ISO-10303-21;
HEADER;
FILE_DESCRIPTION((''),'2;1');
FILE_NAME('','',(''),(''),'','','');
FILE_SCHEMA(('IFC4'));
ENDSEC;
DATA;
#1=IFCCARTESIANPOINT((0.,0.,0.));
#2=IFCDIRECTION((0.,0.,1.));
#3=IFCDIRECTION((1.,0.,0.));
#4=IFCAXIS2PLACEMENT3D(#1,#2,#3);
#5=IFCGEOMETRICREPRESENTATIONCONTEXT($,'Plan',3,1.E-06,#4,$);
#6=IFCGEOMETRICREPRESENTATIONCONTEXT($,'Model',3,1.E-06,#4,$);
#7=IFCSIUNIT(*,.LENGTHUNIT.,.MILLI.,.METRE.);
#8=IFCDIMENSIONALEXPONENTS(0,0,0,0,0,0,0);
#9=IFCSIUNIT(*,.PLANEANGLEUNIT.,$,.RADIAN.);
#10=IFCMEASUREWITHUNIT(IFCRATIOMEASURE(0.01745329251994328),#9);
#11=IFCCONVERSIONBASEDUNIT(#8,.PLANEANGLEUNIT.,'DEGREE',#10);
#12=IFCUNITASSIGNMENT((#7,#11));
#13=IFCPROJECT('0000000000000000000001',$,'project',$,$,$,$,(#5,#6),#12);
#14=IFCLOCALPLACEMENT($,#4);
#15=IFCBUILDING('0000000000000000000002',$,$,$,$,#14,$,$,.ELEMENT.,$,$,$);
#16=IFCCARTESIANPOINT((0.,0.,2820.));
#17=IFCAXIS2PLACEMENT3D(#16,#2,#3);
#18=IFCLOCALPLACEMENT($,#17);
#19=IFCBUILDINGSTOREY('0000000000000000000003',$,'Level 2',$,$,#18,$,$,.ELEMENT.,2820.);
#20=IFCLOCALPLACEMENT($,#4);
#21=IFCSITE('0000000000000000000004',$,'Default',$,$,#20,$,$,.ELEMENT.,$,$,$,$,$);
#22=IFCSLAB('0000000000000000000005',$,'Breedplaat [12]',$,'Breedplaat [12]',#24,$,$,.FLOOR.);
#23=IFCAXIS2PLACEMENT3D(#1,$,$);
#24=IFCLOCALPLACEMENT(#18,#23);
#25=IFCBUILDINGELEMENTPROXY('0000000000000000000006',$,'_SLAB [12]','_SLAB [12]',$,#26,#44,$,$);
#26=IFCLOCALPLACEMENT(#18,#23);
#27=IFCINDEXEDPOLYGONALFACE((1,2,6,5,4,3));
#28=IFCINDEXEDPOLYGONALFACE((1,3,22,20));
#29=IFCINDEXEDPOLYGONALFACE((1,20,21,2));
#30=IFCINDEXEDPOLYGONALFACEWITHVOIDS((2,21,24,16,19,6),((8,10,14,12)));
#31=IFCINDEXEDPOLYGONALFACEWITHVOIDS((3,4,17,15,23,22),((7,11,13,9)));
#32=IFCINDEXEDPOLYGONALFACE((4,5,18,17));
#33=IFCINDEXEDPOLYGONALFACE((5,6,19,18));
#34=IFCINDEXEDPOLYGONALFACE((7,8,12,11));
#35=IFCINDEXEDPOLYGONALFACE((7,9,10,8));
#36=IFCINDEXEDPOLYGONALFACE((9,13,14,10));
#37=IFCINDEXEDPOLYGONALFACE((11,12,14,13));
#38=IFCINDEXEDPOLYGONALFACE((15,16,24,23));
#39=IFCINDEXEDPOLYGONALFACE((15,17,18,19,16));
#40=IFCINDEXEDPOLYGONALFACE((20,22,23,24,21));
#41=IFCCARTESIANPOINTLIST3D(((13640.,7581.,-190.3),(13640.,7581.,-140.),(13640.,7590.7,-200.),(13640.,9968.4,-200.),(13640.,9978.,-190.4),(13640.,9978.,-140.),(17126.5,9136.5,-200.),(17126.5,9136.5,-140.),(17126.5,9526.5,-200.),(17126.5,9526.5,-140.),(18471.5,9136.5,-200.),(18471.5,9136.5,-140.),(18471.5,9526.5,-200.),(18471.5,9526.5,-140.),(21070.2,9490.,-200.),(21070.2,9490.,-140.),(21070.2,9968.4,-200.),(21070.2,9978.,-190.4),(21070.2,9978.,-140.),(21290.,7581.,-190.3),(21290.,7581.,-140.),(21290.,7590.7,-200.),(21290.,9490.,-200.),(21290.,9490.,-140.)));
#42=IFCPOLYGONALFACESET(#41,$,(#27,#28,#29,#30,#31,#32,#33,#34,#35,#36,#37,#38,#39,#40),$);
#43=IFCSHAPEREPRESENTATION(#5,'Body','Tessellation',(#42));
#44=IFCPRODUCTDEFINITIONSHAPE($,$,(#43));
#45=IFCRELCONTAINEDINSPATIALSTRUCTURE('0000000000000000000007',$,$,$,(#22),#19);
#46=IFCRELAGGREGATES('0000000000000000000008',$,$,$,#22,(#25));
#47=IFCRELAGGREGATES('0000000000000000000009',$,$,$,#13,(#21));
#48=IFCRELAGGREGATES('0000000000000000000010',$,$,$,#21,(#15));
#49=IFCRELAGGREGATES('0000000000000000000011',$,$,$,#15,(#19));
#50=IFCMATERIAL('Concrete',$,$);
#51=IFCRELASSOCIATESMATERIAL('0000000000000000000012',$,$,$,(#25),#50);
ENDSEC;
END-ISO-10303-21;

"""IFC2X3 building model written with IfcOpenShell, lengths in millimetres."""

from ifc_helpers import new_model, entity, si_unit, converted_unit, frame, origin_with_axes, origin_2d_with_axis, place, context, project, spatial, polyline, rectangle, outline, extrude, material, element, aggregate, save


model = new_model("IFC2X3")

# Units and contexts
plan_context = context("Plan", 3, precision=1e-06, world=origin_with_axes())
model_context = context("Model", 3, precision=1e-06, world=origin_with_axes())
ifc_project = project(units=[si_unit("LENGTHUNIT", "METRE", prefix="MILLI"), converted_unit("PLANEANGLEUNIT", "DEGREE", entity("IfcRatioMeasure", 0.01745329251994328), si_unit("PLANEANGLEUNIT", "RADIAN"), dimensions=[0, 0, 0, 0, 0, 0, 0])], contexts=[plan_context, model_context])

# Site, building, storey
site_placement = place(None, origin_with_axes())
site = spatial("IfcSite", under=ifc_project, at=site_placement, Name="Default", CompositionType="ELEMENT")
building_placement = place(None, origin_with_axes())
building = spatial("IfcBuilding", under=site, at=building_placement, CompositionType="ELEMENT")
storey_placement = place(None, frame((0.0, 0.0, 2820.0), z_axis=(0.0, 0.0, 1.0), x_axis=(1.0, 0.0, 0.0)))
storey = spatial("IfcBuildingStorey", under=building, at=storey_placement, Name="Level 2", CompositionType="ELEMENT", Elevation=2820.0)

# Slab, building element proxy, openings
slab_1_placement = place(None, frame((13640.0, 7581.0, 2620.0), z_axis=(0.0, 0.0, 1.0), x_axis=(1.0, 0.0, 0.0)))
slab_1 = element("IfcSlab", 1, at=slab_1_placement, inside=storey, Name="Breedplaat [12]", ObjectType="Breedplaat [12]", PredefinedType="FLOOR")
ifc_material = material(Name="Concrete")
proxy_1_placement = place(slab_1_placement, origin_with_axes())
proxy_1 = element("IfcBuildingElementProxy", 2, at=proxy_1_placement, material=ifc_material, Name="_SLAB [12]", Description="_SLAB [12]", context=plan_context, shape_type="SweptSolid", body=[
    extrude(outline(polyline([(7650.0, 1909.0), (7430.1, 1909.0), (7430.1, 2397.0), (0.0, 2397.0), (0.0, 0.0), (7650.0, 0.0), (7650.0, 1909.0)])), origin_with_axes(), (0.0, 0.0, 1.0), 60.0),
])
opening_1_placement = place(slab_1_placement, frame((3486.5, 1555.5, 0.0), z_axis=(0.0, 0.0, 1.0), x_axis=(1.0, 0.0, 0.0)))
element("IfcOpeningElement", 3, at=opening_1_placement, cuts=proxy_1, ObjectType="Opening", context=plan_context, shape_type="SolidModel", body=[
    extrude(rectangle(XDim=1345.0, YDim=390.0, at=origin_2d_with_axis()), frame((672.5, 195.0, 0.0), z_axis=(0.0, 0.0, 1.0), x_axis=(1.0, 0.0, 0.0)), (0.0, 0.0, 1.0), 60.0),
])
opening_2_placement = place(None, frame((13640.0, 7581.0, 2620.0), z_axis=(0.0, 0.0, 1.0), x_axis=(1.0, 0.0, 0.0)))
element("IfcOpeningElement", 4, at=opening_2_placement, cuts=proxy_1, ObjectType="Opening", context=plan_context, shape_type="SweptSolid", body=[
    extrude(outline(polyline([(-0.1, -0.1), (-0.1, 10.0), (10.0, -0.1), (-0.1, -0.1)])), frame((-1.2, -0.1, -0.1), z_axis=(1.0, 0.0, 0.0), x_axis=(0.0, 1.0, 0.0)), (0.0, 0.0, 1.0), 7652.2),
])
opening_3_placement = place(None, frame((13640.0, 7581.0, 2620.0), z_axis=(0.0, 0.0, 1.0), x_axis=(1.0, 0.0, 0.0)))
element("IfcOpeningElement", 5, at=opening_3_placement, cuts=proxy_1, ObjectType="Opening", context=plan_context, shape_type="SweptSolid", body=[
    extrude(outline(polyline([(-0.1, -0.1), (-0.1, 10.0), (10.0, -0.1), (-0.1, -0.1)])), frame((7431.4, 2397.2, -0.1), z_axis=(-1.0, 0.0, 0.0), x_axis=(0.0, -1.0, 0.0)), (0.0, 0.0, 1.0), 7432.4),
])
aggregate(slab_1, [proxy_1])

save(model, "model.ifc")
